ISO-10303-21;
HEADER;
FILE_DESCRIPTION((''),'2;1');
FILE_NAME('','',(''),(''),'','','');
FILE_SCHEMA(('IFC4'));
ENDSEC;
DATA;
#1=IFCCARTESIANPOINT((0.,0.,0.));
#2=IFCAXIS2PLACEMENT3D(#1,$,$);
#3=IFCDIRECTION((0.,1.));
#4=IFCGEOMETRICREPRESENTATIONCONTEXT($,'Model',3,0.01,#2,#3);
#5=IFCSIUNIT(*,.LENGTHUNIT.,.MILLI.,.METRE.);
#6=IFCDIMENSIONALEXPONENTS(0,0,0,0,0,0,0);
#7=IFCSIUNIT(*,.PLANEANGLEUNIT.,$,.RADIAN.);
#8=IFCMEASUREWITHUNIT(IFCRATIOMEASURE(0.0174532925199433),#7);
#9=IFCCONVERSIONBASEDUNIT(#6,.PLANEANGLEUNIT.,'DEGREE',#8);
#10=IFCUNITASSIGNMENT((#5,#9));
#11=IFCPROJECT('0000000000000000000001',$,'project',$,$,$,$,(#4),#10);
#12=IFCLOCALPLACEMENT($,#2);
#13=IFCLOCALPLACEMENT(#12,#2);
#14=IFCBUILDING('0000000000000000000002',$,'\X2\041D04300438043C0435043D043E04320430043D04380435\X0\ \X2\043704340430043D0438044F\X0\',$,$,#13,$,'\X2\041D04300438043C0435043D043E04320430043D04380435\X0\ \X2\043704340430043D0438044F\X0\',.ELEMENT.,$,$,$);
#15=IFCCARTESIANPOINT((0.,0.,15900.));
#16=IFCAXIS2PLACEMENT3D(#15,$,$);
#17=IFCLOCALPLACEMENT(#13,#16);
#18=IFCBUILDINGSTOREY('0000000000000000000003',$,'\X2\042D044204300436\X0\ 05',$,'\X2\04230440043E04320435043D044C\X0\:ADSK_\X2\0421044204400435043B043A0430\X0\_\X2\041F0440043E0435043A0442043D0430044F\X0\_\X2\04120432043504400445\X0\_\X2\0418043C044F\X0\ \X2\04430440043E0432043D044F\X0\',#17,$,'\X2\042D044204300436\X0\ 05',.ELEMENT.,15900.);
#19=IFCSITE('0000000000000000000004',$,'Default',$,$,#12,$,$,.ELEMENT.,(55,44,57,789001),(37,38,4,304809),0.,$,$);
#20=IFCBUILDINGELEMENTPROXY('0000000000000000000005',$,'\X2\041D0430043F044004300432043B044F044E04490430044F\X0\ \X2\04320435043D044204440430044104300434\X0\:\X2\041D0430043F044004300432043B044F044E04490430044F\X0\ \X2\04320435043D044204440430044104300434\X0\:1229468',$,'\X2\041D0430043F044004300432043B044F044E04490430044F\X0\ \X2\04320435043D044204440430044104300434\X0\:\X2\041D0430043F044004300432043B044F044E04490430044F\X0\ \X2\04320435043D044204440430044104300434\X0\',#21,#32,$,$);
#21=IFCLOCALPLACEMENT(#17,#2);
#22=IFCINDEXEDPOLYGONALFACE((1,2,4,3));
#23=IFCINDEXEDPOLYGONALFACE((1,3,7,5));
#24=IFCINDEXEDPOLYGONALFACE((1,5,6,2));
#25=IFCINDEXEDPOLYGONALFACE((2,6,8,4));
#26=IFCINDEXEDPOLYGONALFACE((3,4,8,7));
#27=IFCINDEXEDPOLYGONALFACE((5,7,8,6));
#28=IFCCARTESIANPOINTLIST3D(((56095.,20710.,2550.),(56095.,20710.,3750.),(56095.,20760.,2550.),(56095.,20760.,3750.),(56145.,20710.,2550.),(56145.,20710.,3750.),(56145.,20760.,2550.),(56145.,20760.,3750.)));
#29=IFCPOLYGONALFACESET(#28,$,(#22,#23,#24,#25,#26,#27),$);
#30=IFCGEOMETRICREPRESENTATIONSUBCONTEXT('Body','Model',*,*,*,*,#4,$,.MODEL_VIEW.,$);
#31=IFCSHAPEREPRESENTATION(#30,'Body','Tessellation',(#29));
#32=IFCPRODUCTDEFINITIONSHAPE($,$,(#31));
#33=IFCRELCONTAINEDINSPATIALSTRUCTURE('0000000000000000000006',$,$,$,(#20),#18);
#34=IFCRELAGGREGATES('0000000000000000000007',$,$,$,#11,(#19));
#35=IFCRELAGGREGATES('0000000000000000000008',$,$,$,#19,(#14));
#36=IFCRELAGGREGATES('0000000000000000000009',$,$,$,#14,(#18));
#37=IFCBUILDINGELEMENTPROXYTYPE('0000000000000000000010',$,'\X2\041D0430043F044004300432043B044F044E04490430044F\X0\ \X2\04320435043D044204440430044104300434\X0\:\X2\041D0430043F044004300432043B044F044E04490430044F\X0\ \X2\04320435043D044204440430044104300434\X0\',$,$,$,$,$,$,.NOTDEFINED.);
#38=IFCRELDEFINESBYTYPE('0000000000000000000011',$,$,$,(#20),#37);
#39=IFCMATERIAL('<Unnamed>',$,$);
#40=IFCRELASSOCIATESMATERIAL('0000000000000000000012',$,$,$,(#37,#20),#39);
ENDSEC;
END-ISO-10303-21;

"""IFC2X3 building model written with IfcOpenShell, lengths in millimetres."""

from ifc_helpers import new_model, entity, si_unit, converted_unit, direction, frame, origin, origin_2d_with_axis, place, context, subcontext, project, spatial, rectangle, extrude, source, transform, mapped, material, type_object, type_shapes, element, save


model = new_model("IFC2X3")

# Units and contexts
model_context = context("Model", 3, precision=0.01, world=origin(), true_north=direction((0.0, 1.0)))
body_context = subcontext(model_context, "Body", "Model", "MODEL_VIEW")
ifc_project = project(units=[si_unit("LENGTHUNIT", "METRE", prefix="MILLI"), converted_unit("PLANEANGLEUNIT", "DEGREE", entity("IfcRatioMeasure", 0.0174532925199433), si_unit("PLANEANGLEUNIT", "RADIAN"), dimensions=[0, 0, 0, 0, 0, 0, 0])], contexts=[model_context])

# Site, building, storey
site_placement = place(None, origin())
site = spatial("IfcSite", under=ifc_project, at=site_placement, Name="Default", CompositionType="ELEMENT", RefLatitude=(55, 44, 57, 789001), RefLongitude=(37, 38, 4, 304809), RefElevation=0.0)
building_placement = place(site_placement, origin())
building = spatial("IfcBuilding", under=site, at=building_placement, Name="Наименование здания", LongName="Наименование здания", CompositionType="ELEMENT")
storey_placement = place(building_placement, frame((0.0, 0.0, 15900.0)))
storey = spatial("IfcBuildingStorey", under=building, at=storey_placement, Name="Этаж 05", ObjectType="Уровень:ADSK_Стрелка_Проектная_Вверх_Имя уровня", LongName="Этаж 05", CompositionType="ELEMENT", Elevation=15900.0)

# Building element proxy
ifc_material_1 = material(Name="<Unnamed>")
building_element_proxy_type_1 = type_object("IfcBuildingElementProxyType", Name="Направляющая вентфасад:Направляющая вентфасад", PredefinedType="NOTDEFINED", material=ifc_material_1)
shared_shape_1 = source(origin(), body_context, "Body", "SweptSolid", [
    extrude(rectangle(XDim=50.0, YDim=50.0, at=origin_2d_with_axis()), frame((25.0, -25.0, 0.0), z_axis=(0.0, 0.0, 1.0), x_axis=(-1.0, 0.0, 0.0)), (0.0, 0.0, 1.0), 1200.0),
])
type_shapes(building_element_proxy_type_1, [shared_shape_1])
proxy_1_placement = place(storey_placement, frame((56145.0, 20710.0, 2550.0), z_axis=(0.0, 0.0, 1.0), x_axis=(-1.0, 0.0, 0.0)))
element("IfcBuildingElementProxy", 1, at=proxy_1_placement, inside=storey, type_object=building_element_proxy_type_1, material=ifc_material_1, Name="Направляющая вентфасад:Направляющая вентфасад:1229468", ObjectType="Направляющая вентфасад:Направляющая вентфасад", context=body_context, shape_type="MappedRepresentation", body=[
    mapped(shared_shape_1, transform((0.0, 0.0, 0.0), scale=1.0)),
])

save(model, "model.ifc")
